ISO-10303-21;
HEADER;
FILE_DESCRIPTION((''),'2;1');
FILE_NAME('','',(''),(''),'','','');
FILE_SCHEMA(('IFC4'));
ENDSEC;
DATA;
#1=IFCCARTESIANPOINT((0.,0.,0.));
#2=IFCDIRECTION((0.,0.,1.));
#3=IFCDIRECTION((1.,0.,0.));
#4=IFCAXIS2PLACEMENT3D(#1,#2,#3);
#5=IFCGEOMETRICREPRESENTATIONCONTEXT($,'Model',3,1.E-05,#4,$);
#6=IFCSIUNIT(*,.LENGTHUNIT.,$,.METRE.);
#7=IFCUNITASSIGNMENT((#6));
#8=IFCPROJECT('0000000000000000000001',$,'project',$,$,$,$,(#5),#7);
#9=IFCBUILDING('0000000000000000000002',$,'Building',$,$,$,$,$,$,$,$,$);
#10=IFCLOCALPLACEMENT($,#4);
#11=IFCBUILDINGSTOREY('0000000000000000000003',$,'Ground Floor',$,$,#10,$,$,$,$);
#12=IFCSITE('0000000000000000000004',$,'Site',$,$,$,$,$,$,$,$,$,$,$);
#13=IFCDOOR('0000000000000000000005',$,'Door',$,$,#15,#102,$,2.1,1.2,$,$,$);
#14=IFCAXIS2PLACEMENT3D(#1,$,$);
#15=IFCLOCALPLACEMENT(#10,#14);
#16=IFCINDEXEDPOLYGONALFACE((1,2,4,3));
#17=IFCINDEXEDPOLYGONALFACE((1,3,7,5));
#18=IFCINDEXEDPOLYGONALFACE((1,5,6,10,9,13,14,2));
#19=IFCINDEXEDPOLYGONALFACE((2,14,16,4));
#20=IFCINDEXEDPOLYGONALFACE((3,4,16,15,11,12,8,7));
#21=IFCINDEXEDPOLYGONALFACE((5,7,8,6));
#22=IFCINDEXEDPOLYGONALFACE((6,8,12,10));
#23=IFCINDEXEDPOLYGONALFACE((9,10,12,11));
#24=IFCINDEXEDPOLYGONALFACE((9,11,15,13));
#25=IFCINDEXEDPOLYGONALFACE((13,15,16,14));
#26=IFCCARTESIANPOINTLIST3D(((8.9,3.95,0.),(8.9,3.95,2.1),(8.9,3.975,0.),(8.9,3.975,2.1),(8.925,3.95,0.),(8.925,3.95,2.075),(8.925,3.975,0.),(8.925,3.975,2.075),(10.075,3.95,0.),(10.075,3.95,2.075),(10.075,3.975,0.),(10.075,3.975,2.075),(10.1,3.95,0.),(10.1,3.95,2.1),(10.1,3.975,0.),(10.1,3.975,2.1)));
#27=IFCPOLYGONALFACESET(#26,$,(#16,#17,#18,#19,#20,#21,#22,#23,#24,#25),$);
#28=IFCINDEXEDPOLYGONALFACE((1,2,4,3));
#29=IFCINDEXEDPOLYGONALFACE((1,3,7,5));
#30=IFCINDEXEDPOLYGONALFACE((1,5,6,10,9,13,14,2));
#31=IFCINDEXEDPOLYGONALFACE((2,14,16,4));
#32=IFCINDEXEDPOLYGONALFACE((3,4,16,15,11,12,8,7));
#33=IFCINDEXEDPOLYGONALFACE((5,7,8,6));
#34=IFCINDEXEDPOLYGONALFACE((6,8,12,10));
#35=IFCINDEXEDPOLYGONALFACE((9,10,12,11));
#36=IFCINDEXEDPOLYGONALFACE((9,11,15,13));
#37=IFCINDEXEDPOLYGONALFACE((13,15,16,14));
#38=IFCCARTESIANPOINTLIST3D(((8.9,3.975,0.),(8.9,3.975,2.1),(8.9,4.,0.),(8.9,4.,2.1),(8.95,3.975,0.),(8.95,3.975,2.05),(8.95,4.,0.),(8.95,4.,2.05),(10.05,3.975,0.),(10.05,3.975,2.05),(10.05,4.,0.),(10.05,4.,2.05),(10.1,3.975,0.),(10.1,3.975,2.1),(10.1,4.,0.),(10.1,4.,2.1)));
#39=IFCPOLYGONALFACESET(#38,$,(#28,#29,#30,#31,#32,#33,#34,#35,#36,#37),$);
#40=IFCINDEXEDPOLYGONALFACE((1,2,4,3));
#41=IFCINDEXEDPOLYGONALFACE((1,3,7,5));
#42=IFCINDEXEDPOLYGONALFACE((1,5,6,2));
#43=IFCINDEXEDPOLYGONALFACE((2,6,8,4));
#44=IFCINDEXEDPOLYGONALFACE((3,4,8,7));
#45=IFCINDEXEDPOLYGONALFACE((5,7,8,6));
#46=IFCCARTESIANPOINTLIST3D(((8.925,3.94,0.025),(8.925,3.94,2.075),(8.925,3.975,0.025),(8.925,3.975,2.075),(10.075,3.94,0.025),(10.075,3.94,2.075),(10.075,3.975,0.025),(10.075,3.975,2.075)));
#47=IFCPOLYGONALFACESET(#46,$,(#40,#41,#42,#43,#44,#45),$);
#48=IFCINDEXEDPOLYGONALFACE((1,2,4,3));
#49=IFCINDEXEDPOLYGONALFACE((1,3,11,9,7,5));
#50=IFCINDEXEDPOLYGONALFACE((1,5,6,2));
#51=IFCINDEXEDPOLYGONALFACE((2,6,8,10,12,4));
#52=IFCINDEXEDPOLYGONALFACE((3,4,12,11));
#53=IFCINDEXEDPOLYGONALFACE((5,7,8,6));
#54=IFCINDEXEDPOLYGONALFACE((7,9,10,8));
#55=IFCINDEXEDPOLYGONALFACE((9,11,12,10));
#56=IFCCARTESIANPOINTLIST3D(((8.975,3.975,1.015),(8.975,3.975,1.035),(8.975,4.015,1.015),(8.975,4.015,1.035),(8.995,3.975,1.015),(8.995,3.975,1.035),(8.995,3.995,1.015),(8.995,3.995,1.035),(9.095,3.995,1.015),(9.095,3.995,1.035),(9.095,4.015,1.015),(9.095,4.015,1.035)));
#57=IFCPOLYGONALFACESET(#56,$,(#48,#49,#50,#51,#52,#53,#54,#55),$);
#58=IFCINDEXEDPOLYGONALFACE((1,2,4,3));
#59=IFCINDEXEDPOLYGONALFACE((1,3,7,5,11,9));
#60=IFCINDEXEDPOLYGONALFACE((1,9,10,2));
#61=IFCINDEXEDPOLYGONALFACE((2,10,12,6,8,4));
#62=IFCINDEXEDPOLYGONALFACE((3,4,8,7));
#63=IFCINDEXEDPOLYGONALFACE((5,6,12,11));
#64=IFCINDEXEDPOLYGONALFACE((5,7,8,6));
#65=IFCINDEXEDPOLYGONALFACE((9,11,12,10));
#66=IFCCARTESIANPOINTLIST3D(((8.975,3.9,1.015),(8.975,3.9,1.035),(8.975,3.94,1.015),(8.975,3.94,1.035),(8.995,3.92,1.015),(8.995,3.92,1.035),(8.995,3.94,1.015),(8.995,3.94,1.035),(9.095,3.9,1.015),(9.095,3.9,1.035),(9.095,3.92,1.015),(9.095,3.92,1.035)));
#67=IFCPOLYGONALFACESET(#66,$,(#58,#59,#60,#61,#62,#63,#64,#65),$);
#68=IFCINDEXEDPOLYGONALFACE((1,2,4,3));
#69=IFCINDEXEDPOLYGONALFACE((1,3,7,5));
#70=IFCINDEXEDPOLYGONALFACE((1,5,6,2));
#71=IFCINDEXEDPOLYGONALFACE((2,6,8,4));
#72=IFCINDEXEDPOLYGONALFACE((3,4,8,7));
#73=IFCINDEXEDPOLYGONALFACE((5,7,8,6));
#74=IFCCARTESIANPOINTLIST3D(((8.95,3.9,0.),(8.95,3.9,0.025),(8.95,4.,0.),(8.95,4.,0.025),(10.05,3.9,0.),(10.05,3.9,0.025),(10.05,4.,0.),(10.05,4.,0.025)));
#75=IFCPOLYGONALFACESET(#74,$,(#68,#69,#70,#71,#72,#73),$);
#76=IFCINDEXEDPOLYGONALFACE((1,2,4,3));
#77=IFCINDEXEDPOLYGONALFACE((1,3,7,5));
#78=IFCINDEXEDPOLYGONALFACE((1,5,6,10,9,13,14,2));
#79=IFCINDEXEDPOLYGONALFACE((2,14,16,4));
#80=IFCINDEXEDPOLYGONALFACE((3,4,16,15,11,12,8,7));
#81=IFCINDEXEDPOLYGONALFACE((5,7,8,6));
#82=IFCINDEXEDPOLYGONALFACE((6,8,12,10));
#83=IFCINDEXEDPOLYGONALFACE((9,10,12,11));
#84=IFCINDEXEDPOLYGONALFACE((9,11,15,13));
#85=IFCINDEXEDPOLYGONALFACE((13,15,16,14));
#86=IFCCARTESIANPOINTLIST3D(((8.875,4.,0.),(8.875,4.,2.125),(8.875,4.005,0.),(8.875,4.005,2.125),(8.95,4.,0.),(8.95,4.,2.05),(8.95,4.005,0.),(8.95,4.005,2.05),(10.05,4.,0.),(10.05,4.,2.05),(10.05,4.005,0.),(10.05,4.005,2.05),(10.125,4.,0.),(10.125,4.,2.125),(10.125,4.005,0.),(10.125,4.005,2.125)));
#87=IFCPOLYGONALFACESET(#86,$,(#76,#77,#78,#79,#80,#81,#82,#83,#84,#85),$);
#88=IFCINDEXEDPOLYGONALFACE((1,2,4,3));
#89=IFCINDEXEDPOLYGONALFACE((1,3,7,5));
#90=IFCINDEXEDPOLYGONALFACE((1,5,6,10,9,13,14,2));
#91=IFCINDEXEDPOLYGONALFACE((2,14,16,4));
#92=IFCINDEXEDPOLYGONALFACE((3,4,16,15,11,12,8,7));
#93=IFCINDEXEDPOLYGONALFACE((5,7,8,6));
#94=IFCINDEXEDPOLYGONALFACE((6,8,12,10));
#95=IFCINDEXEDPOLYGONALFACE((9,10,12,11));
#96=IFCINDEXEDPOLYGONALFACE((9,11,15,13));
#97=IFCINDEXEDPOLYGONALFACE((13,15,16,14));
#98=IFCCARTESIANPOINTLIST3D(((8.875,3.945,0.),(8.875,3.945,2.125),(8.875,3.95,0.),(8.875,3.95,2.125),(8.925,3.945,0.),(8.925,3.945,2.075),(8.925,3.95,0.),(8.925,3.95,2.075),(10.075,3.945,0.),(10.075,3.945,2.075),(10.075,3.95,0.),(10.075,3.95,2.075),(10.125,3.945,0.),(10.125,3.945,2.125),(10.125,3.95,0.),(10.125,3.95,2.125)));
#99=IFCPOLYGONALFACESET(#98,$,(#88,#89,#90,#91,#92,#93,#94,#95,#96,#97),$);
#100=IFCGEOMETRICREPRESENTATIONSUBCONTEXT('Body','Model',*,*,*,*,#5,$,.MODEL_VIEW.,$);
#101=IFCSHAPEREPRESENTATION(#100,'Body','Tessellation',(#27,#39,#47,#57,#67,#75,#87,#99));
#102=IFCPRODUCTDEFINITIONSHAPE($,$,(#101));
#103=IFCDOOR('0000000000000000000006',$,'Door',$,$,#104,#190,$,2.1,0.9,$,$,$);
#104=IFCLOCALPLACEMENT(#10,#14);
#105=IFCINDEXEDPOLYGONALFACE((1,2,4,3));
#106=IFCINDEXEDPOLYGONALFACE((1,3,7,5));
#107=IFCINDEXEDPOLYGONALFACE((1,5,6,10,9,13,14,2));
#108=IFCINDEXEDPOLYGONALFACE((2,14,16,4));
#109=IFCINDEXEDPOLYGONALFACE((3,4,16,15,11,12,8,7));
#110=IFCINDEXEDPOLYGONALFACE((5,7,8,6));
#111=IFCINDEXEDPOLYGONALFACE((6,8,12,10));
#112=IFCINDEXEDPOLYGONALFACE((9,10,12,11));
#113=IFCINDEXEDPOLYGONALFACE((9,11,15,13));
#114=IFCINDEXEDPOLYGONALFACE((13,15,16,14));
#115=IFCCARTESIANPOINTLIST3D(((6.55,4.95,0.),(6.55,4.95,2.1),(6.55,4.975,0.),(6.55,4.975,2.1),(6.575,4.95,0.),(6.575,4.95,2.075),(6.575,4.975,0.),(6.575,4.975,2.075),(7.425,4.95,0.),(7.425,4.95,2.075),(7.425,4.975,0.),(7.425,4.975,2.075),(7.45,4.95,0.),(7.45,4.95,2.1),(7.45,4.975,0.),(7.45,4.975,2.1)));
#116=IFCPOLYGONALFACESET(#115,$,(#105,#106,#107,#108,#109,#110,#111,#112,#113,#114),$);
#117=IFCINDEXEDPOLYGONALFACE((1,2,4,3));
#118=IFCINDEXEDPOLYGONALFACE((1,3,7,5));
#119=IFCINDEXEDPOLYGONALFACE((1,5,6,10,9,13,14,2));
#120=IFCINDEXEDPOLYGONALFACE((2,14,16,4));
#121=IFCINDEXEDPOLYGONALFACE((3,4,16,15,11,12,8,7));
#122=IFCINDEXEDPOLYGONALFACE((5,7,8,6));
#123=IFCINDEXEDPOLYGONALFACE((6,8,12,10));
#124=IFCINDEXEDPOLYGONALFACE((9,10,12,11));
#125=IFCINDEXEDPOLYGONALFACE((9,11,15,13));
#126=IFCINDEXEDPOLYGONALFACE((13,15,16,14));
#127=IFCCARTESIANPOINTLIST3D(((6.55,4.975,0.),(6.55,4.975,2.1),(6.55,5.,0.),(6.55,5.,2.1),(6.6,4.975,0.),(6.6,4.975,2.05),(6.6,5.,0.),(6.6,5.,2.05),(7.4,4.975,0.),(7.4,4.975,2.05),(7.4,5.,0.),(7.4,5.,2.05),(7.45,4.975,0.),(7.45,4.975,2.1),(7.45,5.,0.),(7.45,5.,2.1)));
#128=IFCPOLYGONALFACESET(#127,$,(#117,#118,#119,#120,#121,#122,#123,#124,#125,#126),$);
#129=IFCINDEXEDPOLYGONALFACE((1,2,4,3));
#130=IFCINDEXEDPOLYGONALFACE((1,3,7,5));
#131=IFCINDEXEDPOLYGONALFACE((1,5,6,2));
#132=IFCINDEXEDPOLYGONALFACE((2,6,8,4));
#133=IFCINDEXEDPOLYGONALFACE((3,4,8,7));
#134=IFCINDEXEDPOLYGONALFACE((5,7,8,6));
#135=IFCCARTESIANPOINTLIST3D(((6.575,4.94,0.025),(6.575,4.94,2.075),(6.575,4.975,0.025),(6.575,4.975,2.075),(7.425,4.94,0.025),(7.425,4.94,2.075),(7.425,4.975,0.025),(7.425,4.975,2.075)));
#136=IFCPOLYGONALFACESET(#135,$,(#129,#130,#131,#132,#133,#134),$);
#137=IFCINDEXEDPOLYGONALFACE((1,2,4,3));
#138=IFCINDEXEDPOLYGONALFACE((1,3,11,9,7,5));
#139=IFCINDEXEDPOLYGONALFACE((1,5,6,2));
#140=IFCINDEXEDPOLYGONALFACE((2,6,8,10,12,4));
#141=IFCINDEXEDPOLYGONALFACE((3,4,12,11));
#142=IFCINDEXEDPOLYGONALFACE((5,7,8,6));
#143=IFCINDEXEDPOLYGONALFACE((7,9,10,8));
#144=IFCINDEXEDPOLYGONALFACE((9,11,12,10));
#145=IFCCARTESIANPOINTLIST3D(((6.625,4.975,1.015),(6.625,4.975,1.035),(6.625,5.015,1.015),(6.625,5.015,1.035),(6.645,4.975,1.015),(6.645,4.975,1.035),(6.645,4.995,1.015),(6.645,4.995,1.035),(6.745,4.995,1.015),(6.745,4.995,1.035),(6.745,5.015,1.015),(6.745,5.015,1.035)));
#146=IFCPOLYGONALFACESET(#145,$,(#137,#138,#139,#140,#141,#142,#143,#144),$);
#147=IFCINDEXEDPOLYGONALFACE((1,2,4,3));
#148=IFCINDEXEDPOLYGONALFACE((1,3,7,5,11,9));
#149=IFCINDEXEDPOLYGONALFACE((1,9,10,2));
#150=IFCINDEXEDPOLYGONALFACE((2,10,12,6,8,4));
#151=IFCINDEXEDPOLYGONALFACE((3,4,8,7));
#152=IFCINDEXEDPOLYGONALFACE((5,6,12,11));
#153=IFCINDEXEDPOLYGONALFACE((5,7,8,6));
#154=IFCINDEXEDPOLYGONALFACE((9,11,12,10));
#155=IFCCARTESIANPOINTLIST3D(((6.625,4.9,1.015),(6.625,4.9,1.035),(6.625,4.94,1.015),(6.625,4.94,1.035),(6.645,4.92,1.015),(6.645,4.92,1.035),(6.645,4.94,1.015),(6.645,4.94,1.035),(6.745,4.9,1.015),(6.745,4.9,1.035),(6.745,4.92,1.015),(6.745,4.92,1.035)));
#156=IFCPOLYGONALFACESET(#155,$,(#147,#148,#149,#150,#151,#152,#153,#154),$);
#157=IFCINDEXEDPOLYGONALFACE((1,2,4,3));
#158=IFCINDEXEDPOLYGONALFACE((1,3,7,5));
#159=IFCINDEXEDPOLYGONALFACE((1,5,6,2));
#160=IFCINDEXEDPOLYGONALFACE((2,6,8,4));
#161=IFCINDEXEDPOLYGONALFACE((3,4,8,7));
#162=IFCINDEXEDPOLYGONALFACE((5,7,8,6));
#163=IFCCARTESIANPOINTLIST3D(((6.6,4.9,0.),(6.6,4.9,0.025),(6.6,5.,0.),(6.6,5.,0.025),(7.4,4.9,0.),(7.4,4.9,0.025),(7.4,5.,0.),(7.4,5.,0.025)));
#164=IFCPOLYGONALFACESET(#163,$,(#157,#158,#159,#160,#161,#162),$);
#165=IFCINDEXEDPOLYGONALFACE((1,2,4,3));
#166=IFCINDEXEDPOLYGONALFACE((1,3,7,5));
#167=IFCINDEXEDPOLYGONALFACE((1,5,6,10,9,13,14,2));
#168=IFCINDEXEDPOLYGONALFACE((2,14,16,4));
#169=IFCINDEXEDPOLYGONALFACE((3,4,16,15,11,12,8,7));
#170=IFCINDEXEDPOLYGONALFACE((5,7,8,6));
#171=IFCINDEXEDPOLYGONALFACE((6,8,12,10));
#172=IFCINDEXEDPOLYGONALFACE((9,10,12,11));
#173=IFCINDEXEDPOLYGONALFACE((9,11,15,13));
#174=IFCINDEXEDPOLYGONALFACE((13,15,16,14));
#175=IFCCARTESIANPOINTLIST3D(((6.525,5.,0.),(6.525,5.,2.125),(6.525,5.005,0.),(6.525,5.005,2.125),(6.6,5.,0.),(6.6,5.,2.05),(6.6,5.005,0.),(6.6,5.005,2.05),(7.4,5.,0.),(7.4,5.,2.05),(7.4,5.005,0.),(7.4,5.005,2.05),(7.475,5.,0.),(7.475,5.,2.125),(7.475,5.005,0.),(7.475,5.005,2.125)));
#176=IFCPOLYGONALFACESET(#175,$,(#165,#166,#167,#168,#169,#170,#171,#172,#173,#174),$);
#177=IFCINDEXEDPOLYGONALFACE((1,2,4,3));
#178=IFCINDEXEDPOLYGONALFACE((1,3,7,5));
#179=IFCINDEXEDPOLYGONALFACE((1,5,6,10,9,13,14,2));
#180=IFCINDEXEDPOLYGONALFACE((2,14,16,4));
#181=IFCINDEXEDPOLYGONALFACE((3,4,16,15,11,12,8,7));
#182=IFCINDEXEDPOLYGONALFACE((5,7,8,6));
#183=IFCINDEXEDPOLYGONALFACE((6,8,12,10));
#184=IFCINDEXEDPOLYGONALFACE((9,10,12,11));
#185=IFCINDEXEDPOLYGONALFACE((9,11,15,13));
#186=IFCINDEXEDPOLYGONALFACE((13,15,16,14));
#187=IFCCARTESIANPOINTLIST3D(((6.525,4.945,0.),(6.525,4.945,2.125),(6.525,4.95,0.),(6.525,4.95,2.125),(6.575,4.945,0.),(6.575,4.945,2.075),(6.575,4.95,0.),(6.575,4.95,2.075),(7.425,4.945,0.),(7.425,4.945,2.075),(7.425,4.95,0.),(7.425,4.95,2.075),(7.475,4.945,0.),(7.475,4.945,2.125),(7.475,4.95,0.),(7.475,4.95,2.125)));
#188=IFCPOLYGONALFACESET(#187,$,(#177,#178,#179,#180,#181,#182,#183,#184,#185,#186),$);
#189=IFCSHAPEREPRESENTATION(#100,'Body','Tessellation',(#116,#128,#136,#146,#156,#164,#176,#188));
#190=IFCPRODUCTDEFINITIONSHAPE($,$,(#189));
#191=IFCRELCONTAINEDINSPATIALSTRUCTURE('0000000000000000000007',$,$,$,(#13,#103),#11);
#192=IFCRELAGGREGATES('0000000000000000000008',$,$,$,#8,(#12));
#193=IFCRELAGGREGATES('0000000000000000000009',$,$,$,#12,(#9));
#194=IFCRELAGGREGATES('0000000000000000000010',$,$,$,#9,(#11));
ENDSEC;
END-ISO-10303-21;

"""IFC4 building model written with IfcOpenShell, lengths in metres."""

from ifc_helpers import new_model, si_unit, frame, origin_with_axes, place, context, subcontext, project, spatial, line, indexed_curve, outline, extrude, element, save


model = new_model("IFC4")

# Units and contexts
model_context = context("Model", 3, precision=1e-05, world=origin_with_axes())
body_context = subcontext(model_context, "Body", "Model", "MODEL_VIEW")
ifc_project = project(units=[si_unit("LENGTHUNIT", "METRE")], contexts=[model_context])

# Site, building, storey
site = spatial("IfcSite", under=ifc_project, Name="Site")
building = spatial("IfcBuilding", under=site, Name="Building")
storey_placement = place(None, origin_with_axes())
storey = spatial("IfcBuildingStorey", under=building, at=storey_placement, Name="Ground Floor")

# Doors
door_1_placement = place(storey_placement, frame((10.1, 4.0, 0.0), z_axis=(0.0, 0.0, 1.0), x_axis=(-1.0, 0.0, 0.0)))
element("IfcDoor", 1, at=door_1_placement, inside=storey, Name="Door", OverallHeight=2.1, OverallWidth=1.2, context=body_context, shape_type="SweptSolid", body=[
    extrude(outline(indexed_curve([(0.0, 0.0), (0.0, 2.1), (1.2, 2.1), (1.2, 0.0), (1.175, 0.0), (1.175, 2.075), (0.025, 2.075), (0.025, 0.0)], segments=[line(1, 2, 3, 4, 5, 6, 7, 8, 1)])), frame((0.0, 0.025, 0.0), z_axis=(0.0, -1.0, 0.0), x_axis=(1.0, 0.0, 0.0)), (0.0, 0.0, -1.0), 0.025),
    extrude(outline(indexed_curve([(0.0, 0.0), (0.0, 2.1), (1.2, 2.1), (1.2, 0.0), (1.15, 0.0), (1.15, 2.05), (0.05, 2.05), (0.05, 0.0)], segments=[line(1, 2, 3, 4, 5, 6, 7, 8, 1)])), frame((0.0, 0.0, 0.0), z_axis=(0.0, -1.0, 0.0), x_axis=(1.0, 0.0, 0.0)), (0.0, 0.0, -1.0), 0.025),
    extrude(outline(indexed_curve([(0.0, 0.0), (1.15, 0.0), (1.15, 0.035), (0.0, 0.035)], segments=[line(1, 2, 3, 4, 1)])), frame((0.025, 0.025, 0.025), z_axis=(0.0, 0.0, 1.0), x_axis=(1.0, 0.0, 0.0)), (0.0, 0.0, 1.0), 2.05),
    extrude(outline(indexed_curve([(0.0, 0.0), (0.0, -0.04), (-0.12, -0.04), (-0.12, -0.02), (-0.02, -0.02), (-0.02, 0.0)], segments=[line(1, 2, 3, 4, 5, 6, 1)])), frame((1.125, 0.025, 1.015), z_axis=(0.0, 0.0, 1.0), x_axis=(1.0, 0.0, 0.0)), (0.0, 0.0, 1.0), 0.02),
    extrude(outline(indexed_curve([(0.0, 0.0), (0.0, 0.04), (-0.12, 0.04), (-0.12, 0.02), (-0.02, 0.02), (-0.02, 0.0)], segments=[line(1, 2, 3, 4, 5, 6, 1)])), frame((1.125, 0.06, 1.015), z_axis=(0.0, 0.0, 1.0), x_axis=(1.0, 0.0, 0.0)), (0.0, 0.0, 1.0), 0.02),
    extrude(outline(indexed_curve([(0.0, 0.0), (1.1, 0.0), (1.1, 0.1), (0.0, 0.1)], segments=[line(1, 2, 3, 4, 1)])), frame((0.05, 0.0, 0.0), z_axis=(0.0, 0.0, 1.0), x_axis=(1.0, 0.0, 0.0)), (0.0, 0.0, 1.0), 0.025),
    extrude(outline(indexed_curve([(0.0, 0.0), (0.0, 2.125), (1.25, 2.125), (1.25, 0.0), (1.175, 0.0), (1.175, 2.05), (0.075, 2.05), (0.075, 0.0)], segments=[line(1, 2, 3, 4, 5, 6, 7, 8, 1)])), frame((-0.025, -0.005, 0.0), z_axis=(0.0, -1.0, 0.0), x_axis=(1.0, 0.0, 0.0)), (0.0, 0.0, -1.0), 0.005),
    extrude(outline(indexed_curve([(0.0, 0.0), (0.0, 2.125), (1.25, 2.125), (1.25, 0.0), (1.2, 0.0), (1.2, 2.075), (0.05, 2.075), (0.05, 0.0)], segments=[line(1, 2, 3, 4, 5, 6, 7, 8, 1)])), frame((-0.025, 0.05, 0.0), z_axis=(0.0, -1.0, 0.0), x_axis=(1.0, 0.0, 0.0)), (0.0, 0.0, -1.0), 0.005),
])
door_2_placement = place(storey_placement, frame((7.45, 5.0, 0.0), z_axis=(0.0, 0.0, 1.0), x_axis=(-1.0, 0.0, 0.0)))
element("IfcDoor", 2, at=door_2_placement, inside=storey, Name="Door", OverallHeight=2.1, OverallWidth=0.9, context=body_context, shape_type="SweptSolid", body=[
    extrude(outline(indexed_curve([(0.0, 0.0), (0.0, 2.1), (0.9, 2.1), (0.9, 0.0), (0.875, 0.0), (0.875, 2.075), (0.025, 2.075), (0.025, 0.0)], segments=[line(1, 2, 3, 4, 5, 6, 7, 8, 1)])), frame((0.0, 0.025, 0.0), z_axis=(0.0, -1.0, 0.0), x_axis=(1.0, 0.0, 0.0)), (0.0, 0.0, -1.0), 0.025),
    extrude(outline(indexed_curve([(0.0, 0.0), (0.0, 2.1), (0.9, 2.1), (0.9, 0.0), (0.85, 0.0), (0.85, 2.05), (0.05, 2.05), (0.05, 0.0)], segments=[line(1, 2, 3, 4, 5, 6, 7, 8, 1)])), frame((0.0, 0.0, 0.0), z_axis=(0.0, -1.0, 0.0), x_axis=(1.0, 0.0, 0.0)), (0.0, 0.0, -1.0), 0.025),
    extrude(outline(indexed_curve([(0.0, 0.0), (0.85, 0.0), (0.85, 0.035), (0.0, 0.035)], segments=[line(1, 2, 3, 4, 1)])), frame((0.025, 0.025, 0.025), z_axis=(0.0, 0.0, 1.0), x_axis=(1.0, 0.0, 0.0)), (0.0, 0.0, 1.0), 2.05),
    extrude(outline(indexed_curve([(0.0, 0.0), (0.0, -0.04), (-0.12, -0.04), (-0.12, -0.02), (-0.02, -0.02), (-0.02, 0.0)], segments=[line(1, 2, 3, 4, 5, 6, 1)])), frame((0.825, 0.025, 1.015), z_axis=(0.0, 0.0, 1.0), x_axis=(1.0, 0.0, 0.0)), (0.0, 0.0, 1.0), 0.02),
    extrude(outline(indexed_curve([(0.0, 0.0), (0.0, 0.04), (-0.12, 0.04), (-0.12, 0.02), (-0.02, 0.02), (-0.02, 0.0)], segments=[line(1, 2, 3, 4, 5, 6, 1)])), frame((0.825, 0.06, 1.015), z_axis=(0.0, 0.0, 1.0), x_axis=(1.0, 0.0, 0.0)), (0.0, 0.0, 1.0), 0.02),
    extrude(outline(indexed_curve([(0.0, 0.0), (0.8, 0.0), (0.8, 0.1), (0.0, 0.1)], segments=[line(1, 2, 3, 4, 1)])), frame((0.05, 0.0, 0.0), z_axis=(0.0, 0.0, 1.0), x_axis=(1.0, 0.0, 0.0)), (0.0, 0.0, 1.0), 0.025),
    extrude(outline(indexed_curve([(0.0, 0.0), (0.0, 2.125), (0.95, 2.125), (0.95, 0.0), (0.875, 0.0), (0.875, 2.05), (0.075, 2.05), (0.075, 0.0)], segments=[line(1, 2, 3, 4, 5, 6, 7, 8, 1)])), frame((-0.025, -0.005, 0.0), z_axis=(0.0, -1.0, 0.0), x_axis=(1.0, 0.0, 0.0)), (0.0, 0.0, -1.0), 0.005),
    extrude(outline(indexed_curve([(0.0, 0.0), (0.0, 2.125), (0.95, 2.125), (0.95, 0.0), (0.9, 0.0), (0.9, 2.075), (0.05, 2.075), (0.05, 0.0)], segments=[line(1, 2, 3, 4, 5, 6, 7, 8, 1)])), frame((-0.025, 0.05, 0.0), z_axis=(0.0, -1.0, 0.0), x_axis=(1.0, 0.0, 0.0)), (0.0, 0.0, -1.0), 0.005),
])

save(model, "model.ifc")
